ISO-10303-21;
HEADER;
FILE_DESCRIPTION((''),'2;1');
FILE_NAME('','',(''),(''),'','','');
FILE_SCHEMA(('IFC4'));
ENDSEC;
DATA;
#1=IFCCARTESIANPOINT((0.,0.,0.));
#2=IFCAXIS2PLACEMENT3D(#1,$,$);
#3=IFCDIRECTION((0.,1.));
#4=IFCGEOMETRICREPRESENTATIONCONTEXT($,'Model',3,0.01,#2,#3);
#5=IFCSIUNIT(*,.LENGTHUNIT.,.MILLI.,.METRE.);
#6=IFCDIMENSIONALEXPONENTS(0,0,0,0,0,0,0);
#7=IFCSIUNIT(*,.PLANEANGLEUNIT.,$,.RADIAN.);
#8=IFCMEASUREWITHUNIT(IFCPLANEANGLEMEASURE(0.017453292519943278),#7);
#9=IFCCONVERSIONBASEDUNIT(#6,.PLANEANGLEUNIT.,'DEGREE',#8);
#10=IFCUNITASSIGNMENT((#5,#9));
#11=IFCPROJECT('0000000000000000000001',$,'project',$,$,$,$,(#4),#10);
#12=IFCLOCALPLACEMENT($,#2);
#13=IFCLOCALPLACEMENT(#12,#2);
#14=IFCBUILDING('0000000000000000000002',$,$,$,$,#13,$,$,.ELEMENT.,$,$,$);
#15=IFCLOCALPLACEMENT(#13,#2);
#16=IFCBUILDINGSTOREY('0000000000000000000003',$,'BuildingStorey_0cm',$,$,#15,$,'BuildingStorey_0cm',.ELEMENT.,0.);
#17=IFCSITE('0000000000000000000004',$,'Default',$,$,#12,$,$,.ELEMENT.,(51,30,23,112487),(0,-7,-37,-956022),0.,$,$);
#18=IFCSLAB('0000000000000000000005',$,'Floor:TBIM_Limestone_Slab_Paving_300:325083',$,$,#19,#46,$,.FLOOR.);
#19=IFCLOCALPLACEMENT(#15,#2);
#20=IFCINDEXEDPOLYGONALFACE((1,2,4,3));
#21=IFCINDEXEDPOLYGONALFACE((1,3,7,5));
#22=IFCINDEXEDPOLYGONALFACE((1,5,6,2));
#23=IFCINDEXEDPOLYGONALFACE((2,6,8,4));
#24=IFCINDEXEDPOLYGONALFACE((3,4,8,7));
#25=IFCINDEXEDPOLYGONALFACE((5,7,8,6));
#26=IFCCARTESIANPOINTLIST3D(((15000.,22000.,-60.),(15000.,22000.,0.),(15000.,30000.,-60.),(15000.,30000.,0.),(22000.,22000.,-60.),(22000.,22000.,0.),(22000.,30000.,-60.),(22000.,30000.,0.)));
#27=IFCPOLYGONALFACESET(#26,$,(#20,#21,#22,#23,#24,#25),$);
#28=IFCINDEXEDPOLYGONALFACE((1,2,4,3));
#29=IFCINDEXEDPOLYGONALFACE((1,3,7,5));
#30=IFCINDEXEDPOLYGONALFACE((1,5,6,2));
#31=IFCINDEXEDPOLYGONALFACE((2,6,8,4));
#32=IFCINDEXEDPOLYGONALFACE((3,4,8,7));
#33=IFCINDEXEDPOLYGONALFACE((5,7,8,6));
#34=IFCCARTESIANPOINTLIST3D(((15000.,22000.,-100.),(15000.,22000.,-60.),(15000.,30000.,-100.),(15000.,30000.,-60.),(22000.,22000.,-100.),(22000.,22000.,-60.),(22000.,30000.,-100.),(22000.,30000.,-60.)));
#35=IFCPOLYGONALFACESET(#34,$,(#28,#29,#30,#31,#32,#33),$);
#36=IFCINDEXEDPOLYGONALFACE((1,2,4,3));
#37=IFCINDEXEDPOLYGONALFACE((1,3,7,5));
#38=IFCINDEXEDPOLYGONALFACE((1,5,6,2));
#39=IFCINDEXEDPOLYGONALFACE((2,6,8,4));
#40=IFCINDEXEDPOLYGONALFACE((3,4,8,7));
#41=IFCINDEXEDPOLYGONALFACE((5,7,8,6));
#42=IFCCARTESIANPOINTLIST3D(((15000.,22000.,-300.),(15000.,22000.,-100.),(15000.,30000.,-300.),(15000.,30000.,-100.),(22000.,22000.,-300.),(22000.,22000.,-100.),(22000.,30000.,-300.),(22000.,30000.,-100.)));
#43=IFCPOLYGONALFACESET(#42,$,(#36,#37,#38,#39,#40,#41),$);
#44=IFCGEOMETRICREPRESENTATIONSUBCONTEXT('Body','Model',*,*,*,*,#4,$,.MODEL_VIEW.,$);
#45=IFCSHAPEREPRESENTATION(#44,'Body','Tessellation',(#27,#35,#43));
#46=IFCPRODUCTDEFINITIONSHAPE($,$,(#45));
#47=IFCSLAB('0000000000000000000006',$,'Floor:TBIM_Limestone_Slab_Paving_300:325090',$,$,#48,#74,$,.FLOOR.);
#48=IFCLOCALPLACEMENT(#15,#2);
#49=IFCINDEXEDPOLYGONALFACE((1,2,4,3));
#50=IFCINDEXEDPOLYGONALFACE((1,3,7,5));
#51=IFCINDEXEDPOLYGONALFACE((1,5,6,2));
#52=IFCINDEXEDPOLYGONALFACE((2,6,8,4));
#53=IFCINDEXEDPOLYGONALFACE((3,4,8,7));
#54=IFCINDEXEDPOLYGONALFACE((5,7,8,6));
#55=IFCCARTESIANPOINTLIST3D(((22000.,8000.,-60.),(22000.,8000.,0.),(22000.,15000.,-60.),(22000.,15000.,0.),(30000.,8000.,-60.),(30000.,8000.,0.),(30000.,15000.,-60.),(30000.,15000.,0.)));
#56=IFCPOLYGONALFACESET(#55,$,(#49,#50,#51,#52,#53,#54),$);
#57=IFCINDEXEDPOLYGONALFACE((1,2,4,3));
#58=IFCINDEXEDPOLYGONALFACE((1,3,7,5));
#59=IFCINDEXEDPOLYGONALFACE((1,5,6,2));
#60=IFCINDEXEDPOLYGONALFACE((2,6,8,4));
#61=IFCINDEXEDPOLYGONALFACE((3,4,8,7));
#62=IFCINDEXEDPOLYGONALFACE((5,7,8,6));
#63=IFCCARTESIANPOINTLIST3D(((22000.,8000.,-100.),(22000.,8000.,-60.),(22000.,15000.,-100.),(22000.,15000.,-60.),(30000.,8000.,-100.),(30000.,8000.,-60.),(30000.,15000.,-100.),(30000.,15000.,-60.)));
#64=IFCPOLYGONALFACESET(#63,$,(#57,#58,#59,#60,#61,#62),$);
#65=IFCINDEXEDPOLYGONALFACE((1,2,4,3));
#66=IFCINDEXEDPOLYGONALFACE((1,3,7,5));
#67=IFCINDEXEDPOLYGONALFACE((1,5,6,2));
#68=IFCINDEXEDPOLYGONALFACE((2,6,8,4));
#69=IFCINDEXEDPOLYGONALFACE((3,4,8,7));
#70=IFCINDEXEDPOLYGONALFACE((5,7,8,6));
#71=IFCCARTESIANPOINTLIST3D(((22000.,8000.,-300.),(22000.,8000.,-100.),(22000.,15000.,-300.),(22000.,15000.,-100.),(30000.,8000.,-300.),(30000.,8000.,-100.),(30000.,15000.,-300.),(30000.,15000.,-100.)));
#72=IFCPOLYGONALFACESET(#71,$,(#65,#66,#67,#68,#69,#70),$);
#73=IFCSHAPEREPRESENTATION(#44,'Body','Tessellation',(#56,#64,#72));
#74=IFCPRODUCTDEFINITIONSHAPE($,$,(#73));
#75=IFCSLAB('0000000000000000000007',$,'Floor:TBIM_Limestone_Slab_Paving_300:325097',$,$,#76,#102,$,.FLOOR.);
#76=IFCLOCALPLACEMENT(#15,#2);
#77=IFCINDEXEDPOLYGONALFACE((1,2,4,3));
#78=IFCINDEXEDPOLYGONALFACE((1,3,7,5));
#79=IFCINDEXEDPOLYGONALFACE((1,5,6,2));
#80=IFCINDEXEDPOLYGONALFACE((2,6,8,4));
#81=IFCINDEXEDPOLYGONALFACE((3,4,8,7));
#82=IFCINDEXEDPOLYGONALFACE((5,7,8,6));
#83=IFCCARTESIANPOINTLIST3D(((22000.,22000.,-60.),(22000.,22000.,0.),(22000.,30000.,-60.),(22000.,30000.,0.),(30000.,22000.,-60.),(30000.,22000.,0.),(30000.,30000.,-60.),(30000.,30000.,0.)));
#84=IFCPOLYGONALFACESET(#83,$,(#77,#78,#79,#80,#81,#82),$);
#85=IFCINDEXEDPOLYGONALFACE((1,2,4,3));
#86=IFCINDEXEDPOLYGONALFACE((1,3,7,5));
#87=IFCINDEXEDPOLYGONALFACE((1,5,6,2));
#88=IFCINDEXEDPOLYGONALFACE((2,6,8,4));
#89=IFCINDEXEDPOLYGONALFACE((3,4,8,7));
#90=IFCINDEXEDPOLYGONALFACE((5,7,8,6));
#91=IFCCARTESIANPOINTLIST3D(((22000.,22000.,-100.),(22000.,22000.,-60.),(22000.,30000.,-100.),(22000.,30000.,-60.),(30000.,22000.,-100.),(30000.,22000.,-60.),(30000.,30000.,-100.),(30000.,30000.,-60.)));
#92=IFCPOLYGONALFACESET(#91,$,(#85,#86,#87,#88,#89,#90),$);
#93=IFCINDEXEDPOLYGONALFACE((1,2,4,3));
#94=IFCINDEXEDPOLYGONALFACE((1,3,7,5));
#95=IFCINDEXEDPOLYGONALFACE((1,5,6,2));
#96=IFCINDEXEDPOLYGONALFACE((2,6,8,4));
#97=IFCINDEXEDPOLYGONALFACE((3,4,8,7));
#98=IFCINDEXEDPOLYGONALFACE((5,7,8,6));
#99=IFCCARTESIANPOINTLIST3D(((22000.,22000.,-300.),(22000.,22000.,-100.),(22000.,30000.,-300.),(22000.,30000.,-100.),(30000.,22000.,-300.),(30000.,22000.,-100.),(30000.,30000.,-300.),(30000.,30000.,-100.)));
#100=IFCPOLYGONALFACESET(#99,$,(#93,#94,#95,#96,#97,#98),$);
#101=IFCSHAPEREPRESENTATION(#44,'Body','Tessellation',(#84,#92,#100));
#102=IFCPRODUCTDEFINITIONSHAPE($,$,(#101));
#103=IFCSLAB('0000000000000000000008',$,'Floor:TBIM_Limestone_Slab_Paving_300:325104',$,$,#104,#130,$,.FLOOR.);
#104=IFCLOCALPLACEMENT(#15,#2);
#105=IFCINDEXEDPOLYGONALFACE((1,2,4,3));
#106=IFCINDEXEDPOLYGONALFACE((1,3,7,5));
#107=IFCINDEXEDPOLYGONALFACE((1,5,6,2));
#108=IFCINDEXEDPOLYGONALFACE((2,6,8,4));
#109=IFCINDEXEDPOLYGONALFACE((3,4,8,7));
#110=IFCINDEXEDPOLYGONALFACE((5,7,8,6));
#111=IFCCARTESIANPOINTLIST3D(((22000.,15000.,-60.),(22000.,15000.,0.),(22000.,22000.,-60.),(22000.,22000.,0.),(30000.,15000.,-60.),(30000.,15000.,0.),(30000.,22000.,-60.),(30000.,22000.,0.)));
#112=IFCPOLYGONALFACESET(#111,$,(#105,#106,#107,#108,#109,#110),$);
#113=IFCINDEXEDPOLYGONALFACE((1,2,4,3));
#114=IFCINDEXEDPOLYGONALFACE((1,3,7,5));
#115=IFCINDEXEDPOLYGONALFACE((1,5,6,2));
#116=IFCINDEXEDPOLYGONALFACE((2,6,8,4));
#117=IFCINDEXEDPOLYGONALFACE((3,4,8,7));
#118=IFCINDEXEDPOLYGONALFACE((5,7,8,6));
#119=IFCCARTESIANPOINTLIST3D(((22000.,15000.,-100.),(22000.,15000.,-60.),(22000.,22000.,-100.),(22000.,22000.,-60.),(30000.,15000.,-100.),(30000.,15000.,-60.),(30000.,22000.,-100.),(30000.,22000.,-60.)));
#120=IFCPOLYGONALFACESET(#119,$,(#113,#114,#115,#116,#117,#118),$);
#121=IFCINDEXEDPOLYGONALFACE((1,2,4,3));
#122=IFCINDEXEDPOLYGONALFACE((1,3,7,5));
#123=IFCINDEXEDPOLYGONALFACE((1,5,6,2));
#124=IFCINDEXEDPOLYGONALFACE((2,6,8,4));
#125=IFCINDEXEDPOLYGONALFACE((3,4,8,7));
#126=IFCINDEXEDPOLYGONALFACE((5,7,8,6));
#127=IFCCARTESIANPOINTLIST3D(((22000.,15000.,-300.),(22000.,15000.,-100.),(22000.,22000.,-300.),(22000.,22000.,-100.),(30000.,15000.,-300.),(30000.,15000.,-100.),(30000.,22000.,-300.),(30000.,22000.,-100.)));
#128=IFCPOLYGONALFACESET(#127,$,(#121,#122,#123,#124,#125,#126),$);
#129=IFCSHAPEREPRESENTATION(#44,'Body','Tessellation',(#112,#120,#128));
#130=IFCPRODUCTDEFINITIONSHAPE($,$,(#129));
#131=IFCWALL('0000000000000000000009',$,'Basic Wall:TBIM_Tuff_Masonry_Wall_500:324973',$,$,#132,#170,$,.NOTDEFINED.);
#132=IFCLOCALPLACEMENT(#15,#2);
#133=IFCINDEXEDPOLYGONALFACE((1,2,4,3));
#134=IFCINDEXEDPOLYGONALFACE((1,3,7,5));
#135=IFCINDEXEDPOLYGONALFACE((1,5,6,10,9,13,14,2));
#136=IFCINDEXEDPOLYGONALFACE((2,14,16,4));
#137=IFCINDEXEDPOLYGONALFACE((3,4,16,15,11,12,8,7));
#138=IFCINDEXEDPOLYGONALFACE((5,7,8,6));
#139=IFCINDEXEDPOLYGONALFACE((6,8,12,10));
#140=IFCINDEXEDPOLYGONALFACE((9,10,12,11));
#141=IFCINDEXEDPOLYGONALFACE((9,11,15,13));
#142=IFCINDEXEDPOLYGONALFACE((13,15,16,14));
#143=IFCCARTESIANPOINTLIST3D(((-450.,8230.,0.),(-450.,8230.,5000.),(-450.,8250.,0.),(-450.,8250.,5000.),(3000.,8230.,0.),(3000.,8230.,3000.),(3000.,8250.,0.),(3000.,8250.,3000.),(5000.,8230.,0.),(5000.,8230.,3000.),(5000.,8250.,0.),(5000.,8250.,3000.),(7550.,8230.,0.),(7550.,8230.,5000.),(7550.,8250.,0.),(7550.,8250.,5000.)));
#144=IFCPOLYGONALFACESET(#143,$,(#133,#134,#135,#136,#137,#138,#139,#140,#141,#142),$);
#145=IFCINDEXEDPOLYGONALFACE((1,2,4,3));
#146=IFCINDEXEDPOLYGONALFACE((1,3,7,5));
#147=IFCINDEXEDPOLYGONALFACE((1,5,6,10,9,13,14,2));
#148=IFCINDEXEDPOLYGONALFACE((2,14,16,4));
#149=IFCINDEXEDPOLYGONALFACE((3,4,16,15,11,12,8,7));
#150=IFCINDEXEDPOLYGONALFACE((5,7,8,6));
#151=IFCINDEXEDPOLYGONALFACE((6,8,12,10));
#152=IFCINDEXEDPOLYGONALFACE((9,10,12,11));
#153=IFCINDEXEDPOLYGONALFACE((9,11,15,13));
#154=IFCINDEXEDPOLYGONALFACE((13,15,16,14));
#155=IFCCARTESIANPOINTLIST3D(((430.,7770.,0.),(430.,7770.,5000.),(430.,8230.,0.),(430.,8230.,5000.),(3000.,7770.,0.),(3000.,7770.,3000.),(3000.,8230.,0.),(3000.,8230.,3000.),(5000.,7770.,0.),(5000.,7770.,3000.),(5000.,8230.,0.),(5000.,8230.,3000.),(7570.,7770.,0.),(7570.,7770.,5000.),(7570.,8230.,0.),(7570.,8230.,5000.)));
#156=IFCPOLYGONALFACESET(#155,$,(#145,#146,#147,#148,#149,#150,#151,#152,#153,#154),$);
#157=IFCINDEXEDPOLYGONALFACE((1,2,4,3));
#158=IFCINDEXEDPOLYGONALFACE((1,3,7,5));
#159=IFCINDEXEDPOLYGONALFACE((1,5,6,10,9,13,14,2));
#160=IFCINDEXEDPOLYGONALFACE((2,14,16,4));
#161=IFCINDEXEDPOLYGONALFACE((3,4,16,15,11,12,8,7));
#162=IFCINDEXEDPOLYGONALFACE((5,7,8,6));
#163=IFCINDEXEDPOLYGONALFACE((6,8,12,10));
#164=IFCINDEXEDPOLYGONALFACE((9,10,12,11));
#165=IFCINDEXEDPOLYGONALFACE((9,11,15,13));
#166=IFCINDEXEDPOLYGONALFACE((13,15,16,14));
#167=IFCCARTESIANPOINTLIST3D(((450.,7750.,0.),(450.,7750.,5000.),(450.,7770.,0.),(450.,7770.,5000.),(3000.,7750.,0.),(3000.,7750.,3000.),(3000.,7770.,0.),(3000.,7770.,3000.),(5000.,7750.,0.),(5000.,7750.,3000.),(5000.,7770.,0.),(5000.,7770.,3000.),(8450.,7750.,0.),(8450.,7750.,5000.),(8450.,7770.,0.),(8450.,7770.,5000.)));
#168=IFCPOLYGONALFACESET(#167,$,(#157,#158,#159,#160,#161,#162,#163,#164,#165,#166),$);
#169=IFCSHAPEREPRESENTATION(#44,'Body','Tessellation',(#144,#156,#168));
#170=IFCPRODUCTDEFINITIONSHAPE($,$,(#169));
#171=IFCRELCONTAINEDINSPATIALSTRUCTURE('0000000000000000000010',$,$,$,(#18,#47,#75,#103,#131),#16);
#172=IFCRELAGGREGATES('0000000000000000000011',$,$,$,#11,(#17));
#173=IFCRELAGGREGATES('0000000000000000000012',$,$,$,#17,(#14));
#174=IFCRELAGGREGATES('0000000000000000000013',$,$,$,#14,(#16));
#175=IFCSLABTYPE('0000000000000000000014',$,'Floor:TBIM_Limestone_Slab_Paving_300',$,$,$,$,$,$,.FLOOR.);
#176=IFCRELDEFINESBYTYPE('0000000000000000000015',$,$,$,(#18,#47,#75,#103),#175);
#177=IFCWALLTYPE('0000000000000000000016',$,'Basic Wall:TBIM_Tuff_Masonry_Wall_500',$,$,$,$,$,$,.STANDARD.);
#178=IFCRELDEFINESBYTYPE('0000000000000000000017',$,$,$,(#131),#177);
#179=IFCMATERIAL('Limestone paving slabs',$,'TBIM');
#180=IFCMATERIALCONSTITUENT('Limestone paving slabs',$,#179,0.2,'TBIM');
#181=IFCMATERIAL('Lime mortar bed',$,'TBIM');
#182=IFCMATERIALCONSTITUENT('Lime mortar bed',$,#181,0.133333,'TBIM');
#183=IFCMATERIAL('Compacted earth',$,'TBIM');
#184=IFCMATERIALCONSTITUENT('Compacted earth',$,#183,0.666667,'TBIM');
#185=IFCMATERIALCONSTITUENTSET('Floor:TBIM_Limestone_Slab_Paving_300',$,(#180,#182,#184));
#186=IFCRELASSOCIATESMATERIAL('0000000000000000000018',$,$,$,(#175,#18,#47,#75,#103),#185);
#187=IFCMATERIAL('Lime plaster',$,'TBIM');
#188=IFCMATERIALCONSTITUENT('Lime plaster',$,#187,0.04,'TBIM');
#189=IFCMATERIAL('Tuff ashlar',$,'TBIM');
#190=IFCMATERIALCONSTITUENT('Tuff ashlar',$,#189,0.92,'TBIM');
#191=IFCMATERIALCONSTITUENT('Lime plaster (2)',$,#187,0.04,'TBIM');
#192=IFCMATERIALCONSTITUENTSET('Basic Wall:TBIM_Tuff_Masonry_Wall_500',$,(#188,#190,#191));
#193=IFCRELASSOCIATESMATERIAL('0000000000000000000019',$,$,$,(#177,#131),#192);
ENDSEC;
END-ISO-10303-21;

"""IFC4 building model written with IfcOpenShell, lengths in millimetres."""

from ifc_helpers import new_model, entity, si_unit, converted_unit, direction, frame, origin, place, context, subcontext, project, spatial, indexed_curve, outline, extrude, material, constituent, constituent_set, type_object, element, save


model = new_model("IFC4")

# Units and contexts
model_context = context("Model", 3, precision=0.01, world=origin(), true_north=direction((0.0, 1.0)))
body_context = subcontext(model_context, "Body", "Model", "MODEL_VIEW")
ifc_project = project(units=[si_unit("LENGTHUNIT", "METRE", prefix="MILLI"), converted_unit("PLANEANGLEUNIT", "DEGREE", entity("IfcPlaneAngleMeasure", 0.017453292519943278), si_unit("PLANEANGLEUNIT", "RADIAN"), dimensions=[0, 0, 0, 0, 0, 0, 0])], contexts=[model_context])

# Site, building, storey
site_placement = place(None, origin())
site = spatial("IfcSite", under=ifc_project, at=site_placement, Name="Default", CompositionType="ELEMENT", RefLatitude=(51, 30, 23, 112487), RefLongitude=(0, -7, -37, -956022), RefElevation=0.0)
building_placement = place(site_placement, origin())
building = spatial("IfcBuilding", under=site, at=building_placement, CompositionType="ELEMENT")
storey_placement = place(building_placement, origin())
storey = spatial("IfcBuildingStorey", under=building, at=storey_placement, Name="BuildingStorey_0cm", LongName="BuildingStorey_0cm", CompositionType="ELEMENT", Elevation=0.0)

# Slabs
ifc_material_1 = material(Name="Limestone paving slabs", Category="TBIM")
ifc_constituent_1 = constituent(ifc_material_1, Name="Limestone paving slabs", Category="TBIM", fraction=0.2)
ifc_material_2 = material(Name="Lime mortar bed", Category="TBIM")
ifc_constituent_2 = constituent(ifc_material_2, Name="Lime mortar bed", Category="TBIM", fraction=0.133333)
ifc_material_3 = material(Name="Compacted earth", Category="TBIM")
ifc_constituent_3 = constituent(ifc_material_3, Name="Compacted earth", Category="TBIM", fraction=0.666667)
ifc_constituent_set_1 = constituent_set(constituents=[ifc_constituent_1, ifc_constituent_2, ifc_constituent_3], Name="Floor:TBIM_Limestone_Slab_Paving_300")
slab_type = type_object("IfcSlabType", Name="Floor:TBIM_Limestone_Slab_Paving_300", PredefinedType="FLOOR", material=ifc_constituent_set_1)
slab_1_placement = place(storey_placement, origin())
element("IfcSlab", 1, at=slab_1_placement, inside=storey, type_object=slab_type, material=ifc_constituent_set_1, Name="Floor:TBIM_Limestone_Slab_Paving_300:325083", PredefinedType="FLOOR", context=body_context, shape_type="SweptSolid", body=[
    extrude(outline(indexed_curve([(-3500.0, -4000.0), (3500.0, -4000.0), (3500.0, 4000.0), (-3500.0, 4000.0), (-3500.0, -4000.0)], self_intersect=False)), frame((18500.0, 26000.0, -60.0), z_axis=(0.0, 0.0, 1.0), x_axis=(-1.0, 0.0, 0.0)), (0.0, 0.0, 1.0), 60.0),
    extrude(outline(indexed_curve([(-3500.0, -4000.0), (3500.0, -4000.0), (3500.0, 4000.0), (-3500.0, 4000.0), (-3500.0, -4000.0)], self_intersect=False)), frame((18500.0, 26000.0, -100.0), z_axis=(0.0, 0.0, 1.0), x_axis=(-1.0, 0.0, 0.0)), (0.0, 0.0, 1.0), 40.0),
    extrude(outline(indexed_curve([(-3500.0, -4000.0), (3500.0, -4000.0), (3500.0, 4000.0), (-3500.0, 4000.0), (-3500.0, -4000.0)], self_intersect=False)), frame((18500.0, 26000.0, -300.0), z_axis=(0.0, 0.0, 1.0), x_axis=(-1.0, 0.0, 0.0)), (0.0, 0.0, 1.0), 200.0),
])
slab_2_placement = place(storey_placement, origin())
element("IfcSlab", 2, at=slab_2_placement, inside=storey, type_object=slab_type, material=ifc_constituent_set_1, Name="Floor:TBIM_Limestone_Slab_Paving_300:325090", PredefinedType="FLOOR", context=body_context, shape_type="SweptSolid", body=[
    extrude(outline(indexed_curve([(-4000.0, -3500.0), (4000.0, -3500.0), (4000.0, 3500.0), (-4000.0, 3500.0), (-4000.0, -3500.0)], self_intersect=False)), frame((26000.0, 11500.0, -60.0), z_axis=(0.0, 0.0, 1.0), x_axis=(-1.0, 0.0, 0.0)), (0.0, 0.0, 1.0), 60.0),
    extrude(outline(indexed_curve([(-4000.0, -3500.0), (4000.0, -3500.0), (4000.0, 3500.0), (-4000.0, 3500.0), (-4000.0, -3500.0)], self_intersect=False)), frame((26000.0, 11500.0, -100.0), z_axis=(0.0, 0.0, 1.0), x_axis=(-1.0, 0.0, 0.0)), (0.0, 0.0, 1.0), 40.0),
    extrude(outline(indexed_curve([(-4000.0, -3500.0), (4000.0, -3500.0), (4000.0, 3500.0), (-4000.0, 3500.0), (-4000.0, -3500.0)], self_intersect=False)), frame((26000.0, 11500.0, -300.0), z_axis=(0.0, 0.0, 1.0), x_axis=(-1.0, 0.0, 0.0)), (0.0, 0.0, 1.0), 200.0),
])
slab_3_placement = place(storey_placement, origin())
element("IfcSlab", 3, at=slab_3_placement, inside=storey, type_object=slab_type, material=ifc_constituent_set_1, Name="Floor:TBIM_Limestone_Slab_Paving_300:325097", PredefinedType="FLOOR", context=body_context, shape_type="SweptSolid", body=[
    extrude(outline(indexed_curve([(-4000.0, -4000.0), (4000.0, -4000.0), (4000.0, 4000.0), (-4000.0, 4000.0), (-4000.0, -4000.0)], self_intersect=False)), frame((26000.0, 26000.0, -60.0), z_axis=(0.0, 0.0, 1.0), x_axis=(-1.0, 0.0, 0.0)), (0.0, 0.0, 1.0), 60.0),
    extrude(outline(indexed_curve([(-4000.0, -4000.0), (4000.0, -4000.0), (4000.0, 4000.0), (-4000.0, 4000.0), (-4000.0, -4000.0)], self_intersect=False)), frame((26000.0, 26000.0, -100.0), z_axis=(0.0, 0.0, 1.0), x_axis=(-1.0, 0.0, 0.0)), (0.0, 0.0, 1.0), 40.0),
    extrude(outline(indexed_curve([(-4000.0, -4000.0), (4000.0, -4000.0), (4000.0, 4000.0), (-4000.0, 4000.0), (-4000.0, -4000.0)], self_intersect=False)), frame((26000.0, 26000.0, -300.0), z_axis=(0.0, 0.0, 1.0), x_axis=(-1.0, 0.0, 0.0)), (0.0, 0.0, 1.0), 200.0),
])
slab_4_placement = place(storey_placement, origin())
element("IfcSlab", 4, at=slab_4_placement, inside=storey, type_object=slab_type, material=ifc_constituent_set_1, Name="Floor:TBIM_Limestone_Slab_Paving_300:325104", PredefinedType="FLOOR", context=body_context, shape_type="SweptSolid", body=[
    extrude(outline(indexed_curve([(-3500.0, -4000.0), (3500.0, -4000.0), (3500.0, 4000.0), (-3500.0, 4000.0), (-3500.0, -4000.0)], self_intersect=False)), frame((26000.0, 18500.0, -60.0), z_axis=(0.0, 0.0, 1.0), x_axis=(0.0, 1.0, 0.0)), (0.0, 0.0, 1.0), 60.0),
    extrude(outline(indexed_curve([(-3500.0, -4000.0), (3500.0, -4000.0), (3500.0, 4000.0), (-3500.0, 4000.0), (-3500.0, -4000.0)], self_intersect=False)), frame((26000.0, 18500.0, -100.0), z_axis=(0.0, 0.0, 1.0), x_axis=(0.0, 1.0, 0.0)), (0.0, 0.0, 1.0), 40.0),
    extrude(outline(indexed_curve([(-3500.0, -4000.0), (3500.0, -4000.0), (3500.0, 4000.0), (-3500.0, 4000.0), (-3500.0, -4000.0)], self_intersect=False)), frame((26000.0, 18500.0, -300.0), z_axis=(0.0, 0.0, 1.0), x_axis=(0.0, 1.0, 0.0)), (0.0, 0.0, 1.0), 200.0),
])

# Shared definitions
ifc_material_4 = material(Name="Tuff ashlar", Category="TBIM")
ifc_material_5 = material(Name="Lime plaster", Category="TBIM")

# Wall, opening
ifc_constituent_4 = constituent(ifc_material_5, Name="Lime plaster", Category="TBIM", fraction=0.04)
ifc_constituent_5 = constituent(ifc_material_4, Name="Tuff ashlar", Category="TBIM", fraction=0.92)
ifc_constituent_6 = constituent(ifc_material_5, Name="Lime plaster (2)", Category="TBIM", fraction=0.04)
ifc_constituent_set_2 = constituent_set(constituents=[ifc_constituent_4, ifc_constituent_5, ifc_constituent_6], Name="Basic Wall:TBIM_Tuff_Masonry_Wall_500")
wall_type_1 = type_object("IfcWallType", Name="Basic Wall:TBIM_Tuff_Masonry_Wall_500", PredefinedType="STANDARD", material=ifc_constituent_set_2)
wall_1_placement = place(storey_placement, frame((450.0, 8000.0, 0.0)))
wall_1 = element("IfcWall", 5, at=wall_1_placement, inside=storey, type_object=wall_type_1, material=ifc_constituent_set_2, Name="Basic Wall:TBIM_Tuff_Masonry_Wall_500:324973", PredefinedType="NOTDEFINED", context=body_context, shape_type="SweptSolid", body=[
    extrude(outline(indexed_curve([(-2000.0, -4225.0), (3000.0, -4225.0), (3000.0, 3775.0), (-2000.0, 3775.0), (-2000.0, 1225.0), (1000.0, 1225.0), (1000.0, -775.0), (-2000.0, -775.0), (-2000.0, -4225.0)], self_intersect=False)), frame((3325.0, 230.0, 2000.0), z_axis=(0.0, 1.0, 0.0), x_axis=(0.0, 0.0, 1.0)), (0.0, 0.0, 1.0), 20.0),
    extrude(outline(indexed_curve([(-2000.0, -3570.0), (3000.0, -3570.0), (3000.0, 3570.0), (-2000.0, 3570.0), (-2000.0, 1000.0), (1000.0, 1000.0), (1000.0, -1000.0), (-2000.0, -1000.0), (-2000.0, -3570.0)], self_intersect=False)), frame((3550.0, -230.0, 2000.0), z_axis=(0.0, 1.0, 0.0), x_axis=(0.0, 0.0, 1.0)), (0.0, 0.0, 1.0), 460.0),
    extrude(outline(indexed_curve([(-775.0, -1000.0), (-775.0, 2000.0), (-4225.0, 2000.0), (-4225.0, -3000.0), (3775.0, -3000.0), (3775.0, 2000.0), (1225.0, 2000.0), (1225.0, -1000.0), (-775.0, -1000.0)], self_intersect=False)), frame((3775.0, -250.0, 2000.0), z_axis=(0.0, -1.0, 0.0), x_axis=(-1.0, 0.0, 0.0)), (0.0, 0.0, -1.0), 20.0),
])
opening_1_placement = place(wall_1_placement, frame((4550.0, 250.0, 0.0)))
element("IfcOpeningElement", 6, at=opening_1_placement, cuts=wall_1, PredefinedType="OPENING", context=body_context, shape_type="SweptSolid", body=[
    extrude(outline(indexed_curve([(3000.0, 2000.0), (0.0, 2000.0), (0.0, 0.0), (3000.0, 0.0), (3000.0, 2000.0)], self_intersect=False)), frame((0.0, 0.0, 0.0), z_axis=(0.0, -1.0, 0.0), x_axis=(0.0, 0.0, 1.0)), (0.0, 0.0, 1.0), 500.0),
])

save(model, "model.ifc")
